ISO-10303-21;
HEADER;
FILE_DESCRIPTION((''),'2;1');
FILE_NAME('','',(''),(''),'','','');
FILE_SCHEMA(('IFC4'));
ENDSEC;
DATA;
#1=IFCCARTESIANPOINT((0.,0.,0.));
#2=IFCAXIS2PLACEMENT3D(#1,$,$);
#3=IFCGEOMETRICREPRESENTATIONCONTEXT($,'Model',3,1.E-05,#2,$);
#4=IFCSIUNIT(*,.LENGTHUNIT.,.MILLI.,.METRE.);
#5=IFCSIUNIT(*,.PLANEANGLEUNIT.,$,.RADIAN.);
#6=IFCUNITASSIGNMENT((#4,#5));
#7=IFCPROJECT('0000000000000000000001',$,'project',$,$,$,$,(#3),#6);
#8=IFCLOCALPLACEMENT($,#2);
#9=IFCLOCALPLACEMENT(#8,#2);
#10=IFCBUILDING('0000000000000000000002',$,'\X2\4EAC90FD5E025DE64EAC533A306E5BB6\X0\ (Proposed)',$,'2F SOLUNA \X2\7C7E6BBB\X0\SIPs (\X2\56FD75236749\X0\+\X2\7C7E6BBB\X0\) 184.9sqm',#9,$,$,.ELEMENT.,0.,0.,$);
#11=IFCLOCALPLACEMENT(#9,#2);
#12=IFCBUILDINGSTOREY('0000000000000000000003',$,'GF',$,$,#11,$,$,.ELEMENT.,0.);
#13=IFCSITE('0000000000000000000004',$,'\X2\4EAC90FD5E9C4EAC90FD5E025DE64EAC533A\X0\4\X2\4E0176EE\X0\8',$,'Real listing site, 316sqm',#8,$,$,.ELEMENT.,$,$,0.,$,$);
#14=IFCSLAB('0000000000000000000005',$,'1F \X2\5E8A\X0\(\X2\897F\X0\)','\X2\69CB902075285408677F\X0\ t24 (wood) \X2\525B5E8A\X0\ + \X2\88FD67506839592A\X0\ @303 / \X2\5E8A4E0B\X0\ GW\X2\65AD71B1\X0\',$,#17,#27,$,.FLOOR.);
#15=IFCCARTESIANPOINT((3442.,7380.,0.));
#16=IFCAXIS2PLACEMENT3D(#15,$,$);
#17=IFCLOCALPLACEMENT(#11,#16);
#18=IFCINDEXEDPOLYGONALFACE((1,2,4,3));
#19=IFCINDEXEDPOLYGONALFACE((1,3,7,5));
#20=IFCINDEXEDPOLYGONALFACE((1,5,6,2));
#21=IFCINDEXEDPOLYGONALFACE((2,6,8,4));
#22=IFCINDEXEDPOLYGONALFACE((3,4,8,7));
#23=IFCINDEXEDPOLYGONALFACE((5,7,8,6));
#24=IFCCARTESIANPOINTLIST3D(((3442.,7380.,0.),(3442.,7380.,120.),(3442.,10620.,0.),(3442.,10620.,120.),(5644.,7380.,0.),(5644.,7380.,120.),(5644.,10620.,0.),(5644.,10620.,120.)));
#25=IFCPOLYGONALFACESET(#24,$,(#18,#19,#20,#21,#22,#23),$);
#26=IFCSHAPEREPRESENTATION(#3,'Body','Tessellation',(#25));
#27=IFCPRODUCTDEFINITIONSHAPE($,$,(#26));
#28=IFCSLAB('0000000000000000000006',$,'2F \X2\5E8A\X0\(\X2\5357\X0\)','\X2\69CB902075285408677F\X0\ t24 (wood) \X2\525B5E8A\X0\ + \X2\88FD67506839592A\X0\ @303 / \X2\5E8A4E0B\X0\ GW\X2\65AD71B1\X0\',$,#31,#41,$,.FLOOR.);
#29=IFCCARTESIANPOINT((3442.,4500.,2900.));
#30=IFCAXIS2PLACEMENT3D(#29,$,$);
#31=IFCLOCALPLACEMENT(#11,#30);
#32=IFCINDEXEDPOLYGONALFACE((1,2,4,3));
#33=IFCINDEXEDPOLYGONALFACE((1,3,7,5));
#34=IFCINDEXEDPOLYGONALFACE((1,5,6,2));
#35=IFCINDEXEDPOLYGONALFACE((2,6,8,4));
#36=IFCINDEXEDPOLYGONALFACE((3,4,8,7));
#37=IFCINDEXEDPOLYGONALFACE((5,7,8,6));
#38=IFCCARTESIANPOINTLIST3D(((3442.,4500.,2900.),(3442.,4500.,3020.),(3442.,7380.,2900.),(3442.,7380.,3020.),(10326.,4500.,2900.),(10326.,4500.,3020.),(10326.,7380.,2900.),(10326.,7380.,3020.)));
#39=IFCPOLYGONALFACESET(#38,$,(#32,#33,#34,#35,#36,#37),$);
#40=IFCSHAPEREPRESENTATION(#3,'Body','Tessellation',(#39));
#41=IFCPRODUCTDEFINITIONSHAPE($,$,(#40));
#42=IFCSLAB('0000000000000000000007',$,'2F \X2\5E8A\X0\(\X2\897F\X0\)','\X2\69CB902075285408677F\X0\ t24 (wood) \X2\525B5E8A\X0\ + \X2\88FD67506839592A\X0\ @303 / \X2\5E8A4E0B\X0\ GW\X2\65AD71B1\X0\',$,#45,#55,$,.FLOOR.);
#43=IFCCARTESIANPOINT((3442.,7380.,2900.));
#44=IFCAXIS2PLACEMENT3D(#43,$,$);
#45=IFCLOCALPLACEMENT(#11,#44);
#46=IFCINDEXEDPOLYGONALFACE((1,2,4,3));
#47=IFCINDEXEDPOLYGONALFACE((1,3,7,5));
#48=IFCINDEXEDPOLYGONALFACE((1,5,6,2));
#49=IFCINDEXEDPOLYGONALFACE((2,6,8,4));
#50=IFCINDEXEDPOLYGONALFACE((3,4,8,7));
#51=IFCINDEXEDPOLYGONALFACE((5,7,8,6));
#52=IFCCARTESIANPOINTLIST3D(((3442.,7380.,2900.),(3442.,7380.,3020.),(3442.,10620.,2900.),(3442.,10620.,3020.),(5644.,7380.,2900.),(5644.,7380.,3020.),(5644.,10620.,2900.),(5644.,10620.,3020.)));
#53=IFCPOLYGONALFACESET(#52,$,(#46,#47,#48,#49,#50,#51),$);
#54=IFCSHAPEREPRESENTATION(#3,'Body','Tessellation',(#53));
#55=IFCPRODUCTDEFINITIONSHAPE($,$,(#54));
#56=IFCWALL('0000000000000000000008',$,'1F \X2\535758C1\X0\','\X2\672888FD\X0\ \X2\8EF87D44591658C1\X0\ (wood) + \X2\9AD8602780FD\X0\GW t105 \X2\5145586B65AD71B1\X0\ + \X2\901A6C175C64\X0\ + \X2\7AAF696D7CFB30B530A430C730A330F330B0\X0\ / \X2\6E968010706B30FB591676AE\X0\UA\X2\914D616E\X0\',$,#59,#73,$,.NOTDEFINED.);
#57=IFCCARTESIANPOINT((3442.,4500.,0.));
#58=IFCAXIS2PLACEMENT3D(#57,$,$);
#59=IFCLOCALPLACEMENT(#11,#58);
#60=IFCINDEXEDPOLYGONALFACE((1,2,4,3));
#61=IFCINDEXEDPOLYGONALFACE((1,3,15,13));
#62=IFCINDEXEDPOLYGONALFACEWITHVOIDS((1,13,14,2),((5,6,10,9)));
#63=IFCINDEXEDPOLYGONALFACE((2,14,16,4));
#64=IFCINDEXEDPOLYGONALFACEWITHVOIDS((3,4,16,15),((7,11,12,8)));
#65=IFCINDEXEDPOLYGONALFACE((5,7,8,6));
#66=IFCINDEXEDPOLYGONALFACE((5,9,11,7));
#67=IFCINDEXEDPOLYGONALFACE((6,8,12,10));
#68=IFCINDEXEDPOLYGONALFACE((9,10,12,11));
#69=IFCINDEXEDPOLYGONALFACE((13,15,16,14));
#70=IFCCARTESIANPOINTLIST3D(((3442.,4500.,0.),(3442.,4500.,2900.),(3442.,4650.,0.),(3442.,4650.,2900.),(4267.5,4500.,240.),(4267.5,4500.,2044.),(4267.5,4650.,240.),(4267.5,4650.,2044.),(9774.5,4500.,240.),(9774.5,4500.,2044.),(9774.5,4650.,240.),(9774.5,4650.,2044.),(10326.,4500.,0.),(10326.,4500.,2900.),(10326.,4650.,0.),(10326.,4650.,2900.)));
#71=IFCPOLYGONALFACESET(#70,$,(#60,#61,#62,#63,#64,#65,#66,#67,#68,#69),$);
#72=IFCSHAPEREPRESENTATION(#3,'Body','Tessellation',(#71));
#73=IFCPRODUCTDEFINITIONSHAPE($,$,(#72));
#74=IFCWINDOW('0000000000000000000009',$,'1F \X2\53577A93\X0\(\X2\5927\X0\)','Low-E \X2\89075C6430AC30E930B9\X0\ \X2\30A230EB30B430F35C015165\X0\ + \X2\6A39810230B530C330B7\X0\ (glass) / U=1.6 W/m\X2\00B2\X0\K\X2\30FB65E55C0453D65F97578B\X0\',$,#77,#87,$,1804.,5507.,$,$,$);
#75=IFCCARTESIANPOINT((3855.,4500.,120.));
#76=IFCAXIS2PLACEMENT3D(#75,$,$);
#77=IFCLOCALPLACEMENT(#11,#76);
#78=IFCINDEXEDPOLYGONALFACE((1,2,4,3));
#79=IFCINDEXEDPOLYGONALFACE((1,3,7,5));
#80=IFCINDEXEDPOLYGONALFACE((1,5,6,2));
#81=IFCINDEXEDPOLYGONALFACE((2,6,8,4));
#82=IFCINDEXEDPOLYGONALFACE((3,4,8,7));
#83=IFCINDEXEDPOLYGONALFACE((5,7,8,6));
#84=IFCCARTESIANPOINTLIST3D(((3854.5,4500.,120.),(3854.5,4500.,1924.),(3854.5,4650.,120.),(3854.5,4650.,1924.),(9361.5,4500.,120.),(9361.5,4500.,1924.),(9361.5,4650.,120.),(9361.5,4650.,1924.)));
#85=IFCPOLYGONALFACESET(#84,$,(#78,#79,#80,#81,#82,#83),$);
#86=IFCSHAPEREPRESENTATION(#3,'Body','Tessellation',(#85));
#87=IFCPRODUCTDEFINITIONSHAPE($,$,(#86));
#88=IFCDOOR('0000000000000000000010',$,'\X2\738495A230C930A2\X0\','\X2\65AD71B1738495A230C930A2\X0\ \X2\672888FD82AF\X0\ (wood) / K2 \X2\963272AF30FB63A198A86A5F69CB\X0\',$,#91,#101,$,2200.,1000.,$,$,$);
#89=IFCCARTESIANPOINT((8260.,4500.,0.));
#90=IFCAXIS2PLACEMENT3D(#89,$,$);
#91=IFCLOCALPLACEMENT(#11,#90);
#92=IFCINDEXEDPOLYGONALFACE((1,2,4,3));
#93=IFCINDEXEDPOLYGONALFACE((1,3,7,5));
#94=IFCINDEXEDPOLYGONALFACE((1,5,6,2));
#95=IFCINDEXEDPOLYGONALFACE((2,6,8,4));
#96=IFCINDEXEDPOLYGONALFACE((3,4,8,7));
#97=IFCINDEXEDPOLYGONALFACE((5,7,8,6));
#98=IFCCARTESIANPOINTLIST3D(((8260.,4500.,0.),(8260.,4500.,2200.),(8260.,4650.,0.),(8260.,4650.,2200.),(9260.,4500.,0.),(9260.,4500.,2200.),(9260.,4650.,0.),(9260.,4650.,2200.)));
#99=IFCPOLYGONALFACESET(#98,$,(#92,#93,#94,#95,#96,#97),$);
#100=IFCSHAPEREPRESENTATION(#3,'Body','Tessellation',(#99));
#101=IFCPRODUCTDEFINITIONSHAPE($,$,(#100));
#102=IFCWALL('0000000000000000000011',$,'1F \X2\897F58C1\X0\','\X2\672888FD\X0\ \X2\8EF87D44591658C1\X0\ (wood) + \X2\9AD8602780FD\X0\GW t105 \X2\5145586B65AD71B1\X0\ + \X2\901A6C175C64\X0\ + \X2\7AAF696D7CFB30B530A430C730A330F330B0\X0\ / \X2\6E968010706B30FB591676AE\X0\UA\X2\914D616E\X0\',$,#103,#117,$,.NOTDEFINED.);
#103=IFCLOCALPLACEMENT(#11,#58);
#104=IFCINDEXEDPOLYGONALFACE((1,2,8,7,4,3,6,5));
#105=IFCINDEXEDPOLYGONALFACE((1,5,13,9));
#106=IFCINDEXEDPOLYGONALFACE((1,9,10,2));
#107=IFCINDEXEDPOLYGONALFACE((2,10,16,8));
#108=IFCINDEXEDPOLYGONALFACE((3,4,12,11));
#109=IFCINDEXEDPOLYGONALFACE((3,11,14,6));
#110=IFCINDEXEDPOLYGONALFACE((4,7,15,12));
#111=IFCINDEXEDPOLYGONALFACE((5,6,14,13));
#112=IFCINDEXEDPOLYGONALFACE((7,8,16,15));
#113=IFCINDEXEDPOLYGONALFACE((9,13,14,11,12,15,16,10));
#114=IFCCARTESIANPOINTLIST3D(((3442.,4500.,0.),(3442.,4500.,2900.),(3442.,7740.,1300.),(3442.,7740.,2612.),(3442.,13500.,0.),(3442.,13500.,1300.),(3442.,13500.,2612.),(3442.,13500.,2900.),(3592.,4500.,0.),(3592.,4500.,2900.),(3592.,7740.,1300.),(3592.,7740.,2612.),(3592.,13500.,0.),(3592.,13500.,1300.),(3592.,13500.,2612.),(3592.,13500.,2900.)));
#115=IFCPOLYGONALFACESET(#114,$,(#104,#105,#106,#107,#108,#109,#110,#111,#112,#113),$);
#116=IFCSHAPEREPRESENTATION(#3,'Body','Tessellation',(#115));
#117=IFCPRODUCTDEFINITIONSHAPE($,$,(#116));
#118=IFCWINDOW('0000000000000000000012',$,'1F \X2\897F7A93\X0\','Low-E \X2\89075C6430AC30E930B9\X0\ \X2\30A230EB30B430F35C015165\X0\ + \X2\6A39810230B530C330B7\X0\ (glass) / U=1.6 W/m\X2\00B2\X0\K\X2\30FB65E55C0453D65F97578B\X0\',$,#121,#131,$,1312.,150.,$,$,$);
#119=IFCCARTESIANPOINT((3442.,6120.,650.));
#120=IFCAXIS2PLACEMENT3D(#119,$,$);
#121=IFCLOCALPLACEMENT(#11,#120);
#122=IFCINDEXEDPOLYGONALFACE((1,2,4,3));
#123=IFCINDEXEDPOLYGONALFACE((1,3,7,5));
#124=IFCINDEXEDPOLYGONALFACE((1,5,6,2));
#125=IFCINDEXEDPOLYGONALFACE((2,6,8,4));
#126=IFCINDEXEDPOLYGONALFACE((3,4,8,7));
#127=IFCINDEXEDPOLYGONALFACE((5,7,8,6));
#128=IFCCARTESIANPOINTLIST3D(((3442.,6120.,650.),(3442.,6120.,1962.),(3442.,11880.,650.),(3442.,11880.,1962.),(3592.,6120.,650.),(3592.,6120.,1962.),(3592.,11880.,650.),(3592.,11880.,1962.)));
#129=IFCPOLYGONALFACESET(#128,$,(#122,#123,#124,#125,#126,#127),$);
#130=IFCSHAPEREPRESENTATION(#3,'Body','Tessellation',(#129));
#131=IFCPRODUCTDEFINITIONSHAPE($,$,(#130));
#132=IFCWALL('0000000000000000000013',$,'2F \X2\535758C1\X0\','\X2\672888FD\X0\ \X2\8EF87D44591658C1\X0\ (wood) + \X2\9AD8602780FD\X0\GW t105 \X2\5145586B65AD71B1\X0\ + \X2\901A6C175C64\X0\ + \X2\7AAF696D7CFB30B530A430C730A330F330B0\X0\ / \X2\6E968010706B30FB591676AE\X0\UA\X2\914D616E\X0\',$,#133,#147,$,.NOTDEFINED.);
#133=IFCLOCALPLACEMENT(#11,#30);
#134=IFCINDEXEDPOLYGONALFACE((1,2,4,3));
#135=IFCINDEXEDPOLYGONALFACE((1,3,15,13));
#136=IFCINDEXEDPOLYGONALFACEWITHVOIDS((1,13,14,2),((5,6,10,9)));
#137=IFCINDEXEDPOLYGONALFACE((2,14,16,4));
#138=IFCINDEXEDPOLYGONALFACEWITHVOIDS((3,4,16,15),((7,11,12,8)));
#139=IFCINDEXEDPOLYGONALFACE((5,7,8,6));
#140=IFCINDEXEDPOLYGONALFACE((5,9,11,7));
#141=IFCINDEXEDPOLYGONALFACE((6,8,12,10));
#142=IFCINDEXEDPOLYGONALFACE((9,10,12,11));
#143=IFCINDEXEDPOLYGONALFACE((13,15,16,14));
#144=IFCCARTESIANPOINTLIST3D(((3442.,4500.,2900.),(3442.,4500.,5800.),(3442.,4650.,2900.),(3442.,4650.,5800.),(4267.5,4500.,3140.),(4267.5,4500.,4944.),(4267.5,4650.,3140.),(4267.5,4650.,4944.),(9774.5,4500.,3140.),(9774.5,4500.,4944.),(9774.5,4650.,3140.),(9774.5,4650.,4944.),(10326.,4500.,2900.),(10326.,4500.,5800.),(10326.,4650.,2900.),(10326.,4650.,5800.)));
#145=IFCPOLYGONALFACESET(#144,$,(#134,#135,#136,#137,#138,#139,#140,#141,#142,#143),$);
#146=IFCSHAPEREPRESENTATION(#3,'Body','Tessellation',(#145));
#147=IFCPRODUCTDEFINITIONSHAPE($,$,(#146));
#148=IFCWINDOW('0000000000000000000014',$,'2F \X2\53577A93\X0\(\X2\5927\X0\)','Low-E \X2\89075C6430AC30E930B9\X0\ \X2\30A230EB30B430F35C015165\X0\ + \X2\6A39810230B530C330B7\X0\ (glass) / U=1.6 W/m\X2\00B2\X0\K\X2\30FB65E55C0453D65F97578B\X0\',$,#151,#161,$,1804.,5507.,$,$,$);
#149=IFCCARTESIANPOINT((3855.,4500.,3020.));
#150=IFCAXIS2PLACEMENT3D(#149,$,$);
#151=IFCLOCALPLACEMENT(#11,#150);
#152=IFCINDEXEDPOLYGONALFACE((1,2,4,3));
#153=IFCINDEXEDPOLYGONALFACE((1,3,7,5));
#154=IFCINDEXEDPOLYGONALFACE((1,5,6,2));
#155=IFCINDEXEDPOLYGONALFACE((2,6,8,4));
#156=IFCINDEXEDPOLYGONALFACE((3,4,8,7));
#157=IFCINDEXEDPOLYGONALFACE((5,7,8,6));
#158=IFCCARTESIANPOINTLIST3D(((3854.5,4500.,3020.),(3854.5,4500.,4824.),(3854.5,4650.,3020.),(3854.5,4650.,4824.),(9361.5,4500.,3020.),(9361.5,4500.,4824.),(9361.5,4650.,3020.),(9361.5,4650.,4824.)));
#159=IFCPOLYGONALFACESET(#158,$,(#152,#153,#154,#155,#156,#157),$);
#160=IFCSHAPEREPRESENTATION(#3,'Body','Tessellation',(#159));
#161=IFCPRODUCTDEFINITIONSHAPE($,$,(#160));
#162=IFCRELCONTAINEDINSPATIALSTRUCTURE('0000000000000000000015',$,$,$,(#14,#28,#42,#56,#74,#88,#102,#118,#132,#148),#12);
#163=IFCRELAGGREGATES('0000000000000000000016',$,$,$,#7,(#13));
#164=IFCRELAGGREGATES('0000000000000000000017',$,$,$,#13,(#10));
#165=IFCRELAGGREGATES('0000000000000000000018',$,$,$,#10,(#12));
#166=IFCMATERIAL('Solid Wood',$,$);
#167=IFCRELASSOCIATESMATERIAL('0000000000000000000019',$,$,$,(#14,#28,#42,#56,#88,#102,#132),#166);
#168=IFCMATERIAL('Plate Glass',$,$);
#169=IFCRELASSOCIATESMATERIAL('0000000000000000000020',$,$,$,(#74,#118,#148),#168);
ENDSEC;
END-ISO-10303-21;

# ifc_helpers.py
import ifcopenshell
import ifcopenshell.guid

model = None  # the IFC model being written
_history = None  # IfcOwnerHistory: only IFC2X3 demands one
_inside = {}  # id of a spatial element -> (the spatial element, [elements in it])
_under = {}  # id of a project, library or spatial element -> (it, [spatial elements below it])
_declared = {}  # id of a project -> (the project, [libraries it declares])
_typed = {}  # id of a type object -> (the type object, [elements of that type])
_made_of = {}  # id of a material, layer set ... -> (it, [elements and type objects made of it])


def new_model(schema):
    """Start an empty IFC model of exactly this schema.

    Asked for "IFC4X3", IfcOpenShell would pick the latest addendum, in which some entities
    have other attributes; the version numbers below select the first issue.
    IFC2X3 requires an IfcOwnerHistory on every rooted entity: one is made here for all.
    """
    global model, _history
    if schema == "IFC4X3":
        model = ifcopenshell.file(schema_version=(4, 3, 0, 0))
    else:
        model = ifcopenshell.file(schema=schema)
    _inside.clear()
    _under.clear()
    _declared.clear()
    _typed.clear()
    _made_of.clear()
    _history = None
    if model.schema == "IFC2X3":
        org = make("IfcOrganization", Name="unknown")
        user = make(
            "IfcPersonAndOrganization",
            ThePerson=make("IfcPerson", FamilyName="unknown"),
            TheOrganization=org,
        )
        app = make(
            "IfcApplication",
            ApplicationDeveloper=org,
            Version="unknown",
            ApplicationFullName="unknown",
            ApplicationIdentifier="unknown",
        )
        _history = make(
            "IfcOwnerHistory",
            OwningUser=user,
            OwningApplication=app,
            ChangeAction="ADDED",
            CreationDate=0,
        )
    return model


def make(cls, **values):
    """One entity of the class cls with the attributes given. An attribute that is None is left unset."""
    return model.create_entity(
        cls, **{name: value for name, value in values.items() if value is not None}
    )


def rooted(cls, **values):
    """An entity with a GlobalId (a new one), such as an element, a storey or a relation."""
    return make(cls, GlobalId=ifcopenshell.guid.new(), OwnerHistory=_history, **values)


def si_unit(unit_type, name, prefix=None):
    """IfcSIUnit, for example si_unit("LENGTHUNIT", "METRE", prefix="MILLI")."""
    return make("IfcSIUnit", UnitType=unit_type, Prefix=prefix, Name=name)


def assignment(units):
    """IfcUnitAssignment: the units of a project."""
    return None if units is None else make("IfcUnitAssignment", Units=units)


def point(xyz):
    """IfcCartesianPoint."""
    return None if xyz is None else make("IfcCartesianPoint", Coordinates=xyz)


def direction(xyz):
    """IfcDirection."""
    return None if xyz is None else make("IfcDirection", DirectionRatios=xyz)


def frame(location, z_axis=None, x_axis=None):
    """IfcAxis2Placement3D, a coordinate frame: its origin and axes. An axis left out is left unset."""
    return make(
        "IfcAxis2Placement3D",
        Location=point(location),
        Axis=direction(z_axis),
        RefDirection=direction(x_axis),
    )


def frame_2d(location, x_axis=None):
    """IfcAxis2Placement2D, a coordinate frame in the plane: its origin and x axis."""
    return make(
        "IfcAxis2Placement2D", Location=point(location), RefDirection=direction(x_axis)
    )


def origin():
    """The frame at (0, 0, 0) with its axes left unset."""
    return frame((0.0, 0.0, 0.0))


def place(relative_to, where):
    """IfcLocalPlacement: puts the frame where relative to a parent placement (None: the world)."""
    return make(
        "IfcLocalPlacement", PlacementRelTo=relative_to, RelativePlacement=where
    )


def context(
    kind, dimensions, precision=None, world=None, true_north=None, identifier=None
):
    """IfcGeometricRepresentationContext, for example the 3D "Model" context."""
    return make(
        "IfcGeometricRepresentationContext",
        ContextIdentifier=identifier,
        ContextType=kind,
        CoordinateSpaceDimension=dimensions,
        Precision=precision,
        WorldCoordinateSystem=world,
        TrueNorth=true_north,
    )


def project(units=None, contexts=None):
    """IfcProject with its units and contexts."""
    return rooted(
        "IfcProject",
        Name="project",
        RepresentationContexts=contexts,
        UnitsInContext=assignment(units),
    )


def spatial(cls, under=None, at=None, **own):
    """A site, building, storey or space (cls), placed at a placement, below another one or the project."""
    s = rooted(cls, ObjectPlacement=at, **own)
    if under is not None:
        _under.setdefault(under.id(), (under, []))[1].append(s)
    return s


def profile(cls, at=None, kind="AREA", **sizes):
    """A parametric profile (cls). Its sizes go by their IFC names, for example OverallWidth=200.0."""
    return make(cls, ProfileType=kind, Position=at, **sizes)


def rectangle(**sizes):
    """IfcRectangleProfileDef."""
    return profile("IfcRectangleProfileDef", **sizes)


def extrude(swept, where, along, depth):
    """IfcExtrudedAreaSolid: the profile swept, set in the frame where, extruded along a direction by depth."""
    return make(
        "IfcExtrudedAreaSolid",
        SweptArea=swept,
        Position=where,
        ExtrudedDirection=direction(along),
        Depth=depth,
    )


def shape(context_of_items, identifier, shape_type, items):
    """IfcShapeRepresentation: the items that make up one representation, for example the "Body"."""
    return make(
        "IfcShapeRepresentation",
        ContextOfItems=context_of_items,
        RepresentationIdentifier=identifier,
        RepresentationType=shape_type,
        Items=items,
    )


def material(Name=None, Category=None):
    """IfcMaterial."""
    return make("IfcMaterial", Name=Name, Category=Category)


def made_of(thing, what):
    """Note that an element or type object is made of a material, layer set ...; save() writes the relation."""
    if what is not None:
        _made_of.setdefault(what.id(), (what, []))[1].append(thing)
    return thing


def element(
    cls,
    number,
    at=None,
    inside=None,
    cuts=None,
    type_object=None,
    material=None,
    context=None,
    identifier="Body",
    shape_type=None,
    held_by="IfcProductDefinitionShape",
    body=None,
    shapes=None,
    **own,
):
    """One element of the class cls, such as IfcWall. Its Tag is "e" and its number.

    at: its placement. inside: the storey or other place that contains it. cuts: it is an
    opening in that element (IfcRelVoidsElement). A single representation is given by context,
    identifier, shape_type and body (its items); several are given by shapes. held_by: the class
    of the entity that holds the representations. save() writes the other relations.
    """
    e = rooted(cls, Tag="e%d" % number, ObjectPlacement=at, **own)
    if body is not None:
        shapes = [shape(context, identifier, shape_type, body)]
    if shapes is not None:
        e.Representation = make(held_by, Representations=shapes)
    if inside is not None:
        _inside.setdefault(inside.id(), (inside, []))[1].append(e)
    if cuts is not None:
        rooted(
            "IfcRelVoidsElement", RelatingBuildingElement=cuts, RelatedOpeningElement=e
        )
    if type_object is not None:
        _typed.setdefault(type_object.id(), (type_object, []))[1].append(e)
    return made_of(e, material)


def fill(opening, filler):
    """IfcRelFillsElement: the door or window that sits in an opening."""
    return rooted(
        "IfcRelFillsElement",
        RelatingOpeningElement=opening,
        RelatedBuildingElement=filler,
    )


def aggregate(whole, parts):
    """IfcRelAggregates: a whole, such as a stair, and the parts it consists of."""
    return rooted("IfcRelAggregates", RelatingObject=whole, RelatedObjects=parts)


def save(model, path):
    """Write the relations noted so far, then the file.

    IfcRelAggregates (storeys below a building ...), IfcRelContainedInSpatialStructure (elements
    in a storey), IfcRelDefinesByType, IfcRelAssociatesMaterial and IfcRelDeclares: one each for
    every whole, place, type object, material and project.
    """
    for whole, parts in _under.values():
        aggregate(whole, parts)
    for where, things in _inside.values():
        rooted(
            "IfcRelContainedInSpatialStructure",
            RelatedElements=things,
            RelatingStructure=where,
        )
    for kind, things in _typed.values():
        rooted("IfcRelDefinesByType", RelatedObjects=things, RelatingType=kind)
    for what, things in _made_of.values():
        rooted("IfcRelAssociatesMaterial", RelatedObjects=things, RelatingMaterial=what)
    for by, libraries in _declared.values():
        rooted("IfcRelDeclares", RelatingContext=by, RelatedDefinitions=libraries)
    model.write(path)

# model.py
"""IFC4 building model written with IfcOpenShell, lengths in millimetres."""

from ifc_helpers import new_model, si_unit, frame, frame_2d, origin, place, context, project, spatial, rectangle, extrude, material, element, fill, save


model = new_model("IFC4")

# Units and contexts
model_context = context("Model", 3, precision=1e-05, world=origin())
ifc_project = project(units=[si_unit("LENGTHUNIT", "METRE", prefix="MILLI"), si_unit("PLANEANGLEUNIT", "RADIAN")], contexts=[model_context])

# Site, building, storey
site_placement = place(None, origin())
site = spatial("IfcSite", under=ifc_project, at=site_placement, Name="京都府京都市左京区4丁目8", ObjectType="Real listing site, 316sqm", CompositionType="ELEMENT", RefElevation=0.0)
building_placement = place(site_placement, origin())
building = spatial("IfcBuilding", under=site, at=building_placement, Name="京都市左京区の家 (Proposed)", ObjectType="2F SOLUNA 籾殻SIPs (国産杉+籾殻) 184.9sqm", CompositionType="ELEMENT", ElevationOfRefHeight=0.0, ElevationOfTerrain=0.0)
storey_placement = place(building_placement, origin())
storey = spatial("IfcBuildingStorey", under=building, at=storey_placement, Name="GF", CompositionType="ELEMENT", Elevation=0.0)

# Slabs
ifc_material_1 = material(Name="Solid Wood")
slab_1_placement = place(storey_placement, frame((3442.0, 7380.0, 0.0)))
element("IfcSlab", 1, at=slab_1_placement, inside=storey, material=ifc_material_1, Name="1F 床(西)", Description="構造用合板 t24 (wood) 剛床 + 製材根太 @303 / 床下 GW断熱", PredefinedType="FLOOR", context=model_context, shape_type="SweptSolid", body=[
    extrude(rectangle(XDim=2202.0, YDim=3240.0, at=frame_2d((1101.0, 1620.0))), frame((3442.0, 7380.0, 0.0)), (0.0, 0.0, 1.0), 120.0),
])
slab_2_placement = place(storey_placement, frame((3442.0, 4500.0, 2900.0)))
element("IfcSlab", 2, at=slab_2_placement, inside=storey, material=ifc_material_1, Name="2F 床(南)", Description="構造用合板 t24 (wood) 剛床 + 製材根太 @303 / 床下 GW断熱", PredefinedType="FLOOR", context=model_context, shape_type="SweptSolid", body=[
    extrude(rectangle(XDim=6884.0, YDim=2880.0, at=frame_2d((3442.0, 1440.0))), frame((3442.0, 4500.0, 2900.0)), (0.0, 0.0, 1.0), 120.0),
])
slab_3_placement = place(storey_placement, frame((3442.0, 7380.0, 2900.0)))
element("IfcSlab", 3, at=slab_3_placement, inside=storey, material=ifc_material_1, Name="2F 床(西)", Description="構造用合板 t24 (wood) 剛床 + 製材根太 @303 / 床下 GW断熱", PredefinedType="FLOOR", context=model_context, shape_type="SweptSolid", body=[
    extrude(rectangle(XDim=2202.0, YDim=3240.0, at=frame_2d((1101.0, 1620.0))), frame((3442.0, 7380.0, 2900.0)), (0.0, 0.0, 1.0), 120.0),
])

# Wall, openings, window, door
wall_1_placement = place(storey_placement, frame((3442.0, 4500.0, 0.0)))
wall_1 = element("IfcWall", 4, at=wall_1_placement, inside=storey, material=ifc_material_1, Name="1F 南壁", Description="木製 軸組外壁 (wood) + 高性能GW t105 充填断熱 + 通気層 + 窯業系サイディング / 準耐火・外皮UA配慮", PredefinedType="NOTDEFINED", context=model_context, shape_type="SweptSolid", body=[
    extrude(rectangle(XDim=6884.0, YDim=150.0, at=frame_2d((3442.0, 75.0))), frame((3442.0, 4500.0, 0.0)), (0.0, 0.0, 1.0), 2900.0),
])
opening_1_placement = place(storey_placement, frame((3855.0, 4500.0, 120.0)))
opening_1 = element("IfcOpeningElement", 5, at=opening_1_placement, cuts=wall_1, PredefinedType="NOTDEFINED", context=model_context, shape_type="SweptSolid", body=[
    extrude(rectangle(XDim=5507.0, YDim=150.0, at=frame_2d((2753.0, 75.0))), frame((3855.0, 4500.0, 120.0)), (0.0, 0.0, 1.0), 1804.0),
])
opening_2_placement = place(storey_placement, frame((8260.0, 4500.0, 0.0)))
opening_2 = element("IfcOpeningElement", 6, at=opening_2_placement, cuts=wall_1, PredefinedType="NOTDEFINED", context=model_context, shape_type="SweptSolid", body=[
    extrude(rectangle(XDim=1000.0, YDim=150.0, at=frame_2d((500.0, 75.0))), frame((8260.0, 4500.0, 0.0)), (0.0, 0.0, 1.0), 2200.0),
])
ifc_material_2 = material(Name="Plate Glass")
window_1_placement = place(storey_placement, frame((3855.0, 4500.0, 120.0)))
window_1 = element("IfcWindow", 7, at=window_1_placement, inside=storey, material=ifc_material_2, Name="1F 南窓(大)", Description="Low-E 複層ガラス アルゴン封入 + 樹脂サッシ (glass) / U=1.6 W/m²K・日射取得型", OverallHeight=1804.0, OverallWidth=5507.0, context=model_context, shape_type="SweptSolid", body=[
    extrude(rectangle(XDim=5507.0, YDim=150.0, at=frame_2d((2753.0, 75.0))), frame((3855.0, 4500.0, 120.0)), (0.0, 0.0, 1.0), 1804.0),
])
fill(opening_1, window_1)
door_placement = place(storey_placement, frame((8260.0, 4500.0, 0.0)))
door = element("IfcDoor", 8, at=door_placement, inside=storey, material=ifc_material_1, Name="玄関ドア", Description="断熱玄関ドア 木製芯 (wood) / K2 防犯・採風機構", OverallHeight=2200.0, OverallWidth=1000.0, context=model_context, shape_type="SweptSolid", body=[
    extrude(rectangle(XDim=1000.0, YDim=150.0, at=frame_2d((500.0, 75.0))), frame((8260.0, 4500.0, 0.0)), (0.0, 0.0, 1.0), 2200.0),
])
fill(opening_2, door)

# Walls, openings, windows
wall_2_placement = place(storey_placement, frame((3442.0, 4500.0, 0.0)))
wall_2 = element("IfcWall", 9, at=wall_2_placement, inside=storey, material=ifc_material_1, Name="1F 西壁", Description="木製 軸組外壁 (wood) + 高性能GW t105 充填断熱 + 通気層 + 窯業系サイディング / 準耐火・外皮UA配慮", PredefinedType="NOTDEFINED", context=model_context, shape_type="SweptSolid", body=[
    extrude(rectangle(XDim=150.0, YDim=9000.0, at=frame_2d((75.0, 4500.0))), frame((3442.0, 4500.0, 0.0)), (0.0, 0.0, 1.0), 2900.0),
])
opening_3_placement = place(storey_placement, frame((3442.0, 6120.0, 650.0)))
opening_3 = element("IfcOpeningElement", 10, at=opening_3_placement, cuts=wall_2, PredefinedType="NOTDEFINED", context=model_context, shape_type="SweptSolid", body=[
    extrude(rectangle(XDim=150.0, YDim=5760.0, at=frame_2d((75.0, 2880.0))), frame((3442.0, 6120.0, 650.0)), (0.0, 0.0, 1.0), 1312.0),
])
window_2_placement = place(storey_placement, frame((3442.0, 6120.0, 650.0)))
window_2 = element("IfcWindow", 11, at=window_2_placement, inside=storey, material=ifc_material_2, Name="1F 西窓", Description="Low-E 複層ガラス アルゴン封入 + 樹脂サッシ (glass) / U=1.6 W/m²K・日射取得型", OverallHeight=1312.0, OverallWidth=150.0, context=model_context, shape_type="SweptSolid", body=[
    extrude(rectangle(XDim=150.0, YDim=5760.0, at=frame_2d((75.0, 2880.0))), frame((3442.0, 6120.0, 650.0)), (0.0, 0.0, 1.0), 1312.0),
])
fill(opening_3, window_2)
wall_3_placement = place(storey_placement, frame((3442.0, 4500.0, 2900.0)))
wall_3 = element("IfcWall", 12, at=wall_3_placement, inside=storey, material=ifc_material_1, Name="2F 南壁", Description="木製 軸組外壁 (wood) + 高性能GW t105 充填断熱 + 通気層 + 窯業系サイディング / 準耐火・外皮UA配慮", PredefinedType="NOTDEFINED", context=model_context, shape_type="SweptSolid", body=[
    extrude(rectangle(XDim=6884.0, YDim=150.0, at=frame_2d((3442.0, 75.0))), frame((3442.0, 4500.0, 2900.0)), (0.0, 0.0, 1.0), 2900.0),
])
opening_4_placement = place(storey_placement, frame((3855.0, 4500.0, 3020.0)))
opening_4 = element("IfcOpeningElement", 13, at=opening_4_placement, cuts=wall_3, PredefinedType="NOTDEFINED", context=model_context, shape_type="SweptSolid", body=[
    extrude(rectangle(XDim=5507.0, YDim=150.0, at=frame_2d((2753.0, 75.0))), frame((3855.0, 4500.0, 3020.0)), (0.0, 0.0, 1.0), 1804.0),
])
window_3_placement = place(storey_placement, frame((3855.0, 4500.0, 3020.0)))
window_3 = element("IfcWindow", 14, at=window_3_placement, inside=storey, material=ifc_material_2, Name="2F 南窓(大)", Description="Low-E 複層ガラス アルゴン封入 + 樹脂サッシ (glass) / U=1.6 W/m²K・日射取得型", OverallHeight=1804.0, OverallWidth=5507.0, context=model_context, shape_type="SweptSolid", body=[
    extrude(rectangle(XDim=5507.0, YDim=150.0, at=frame_2d((2753.0, 75.0))), frame((3855.0, 4500.0, 3020.0)), (0.0, 0.0, 1.0), 1804.0),
])
fill(opening_4, window_3)

save(model, "model.ifc")
